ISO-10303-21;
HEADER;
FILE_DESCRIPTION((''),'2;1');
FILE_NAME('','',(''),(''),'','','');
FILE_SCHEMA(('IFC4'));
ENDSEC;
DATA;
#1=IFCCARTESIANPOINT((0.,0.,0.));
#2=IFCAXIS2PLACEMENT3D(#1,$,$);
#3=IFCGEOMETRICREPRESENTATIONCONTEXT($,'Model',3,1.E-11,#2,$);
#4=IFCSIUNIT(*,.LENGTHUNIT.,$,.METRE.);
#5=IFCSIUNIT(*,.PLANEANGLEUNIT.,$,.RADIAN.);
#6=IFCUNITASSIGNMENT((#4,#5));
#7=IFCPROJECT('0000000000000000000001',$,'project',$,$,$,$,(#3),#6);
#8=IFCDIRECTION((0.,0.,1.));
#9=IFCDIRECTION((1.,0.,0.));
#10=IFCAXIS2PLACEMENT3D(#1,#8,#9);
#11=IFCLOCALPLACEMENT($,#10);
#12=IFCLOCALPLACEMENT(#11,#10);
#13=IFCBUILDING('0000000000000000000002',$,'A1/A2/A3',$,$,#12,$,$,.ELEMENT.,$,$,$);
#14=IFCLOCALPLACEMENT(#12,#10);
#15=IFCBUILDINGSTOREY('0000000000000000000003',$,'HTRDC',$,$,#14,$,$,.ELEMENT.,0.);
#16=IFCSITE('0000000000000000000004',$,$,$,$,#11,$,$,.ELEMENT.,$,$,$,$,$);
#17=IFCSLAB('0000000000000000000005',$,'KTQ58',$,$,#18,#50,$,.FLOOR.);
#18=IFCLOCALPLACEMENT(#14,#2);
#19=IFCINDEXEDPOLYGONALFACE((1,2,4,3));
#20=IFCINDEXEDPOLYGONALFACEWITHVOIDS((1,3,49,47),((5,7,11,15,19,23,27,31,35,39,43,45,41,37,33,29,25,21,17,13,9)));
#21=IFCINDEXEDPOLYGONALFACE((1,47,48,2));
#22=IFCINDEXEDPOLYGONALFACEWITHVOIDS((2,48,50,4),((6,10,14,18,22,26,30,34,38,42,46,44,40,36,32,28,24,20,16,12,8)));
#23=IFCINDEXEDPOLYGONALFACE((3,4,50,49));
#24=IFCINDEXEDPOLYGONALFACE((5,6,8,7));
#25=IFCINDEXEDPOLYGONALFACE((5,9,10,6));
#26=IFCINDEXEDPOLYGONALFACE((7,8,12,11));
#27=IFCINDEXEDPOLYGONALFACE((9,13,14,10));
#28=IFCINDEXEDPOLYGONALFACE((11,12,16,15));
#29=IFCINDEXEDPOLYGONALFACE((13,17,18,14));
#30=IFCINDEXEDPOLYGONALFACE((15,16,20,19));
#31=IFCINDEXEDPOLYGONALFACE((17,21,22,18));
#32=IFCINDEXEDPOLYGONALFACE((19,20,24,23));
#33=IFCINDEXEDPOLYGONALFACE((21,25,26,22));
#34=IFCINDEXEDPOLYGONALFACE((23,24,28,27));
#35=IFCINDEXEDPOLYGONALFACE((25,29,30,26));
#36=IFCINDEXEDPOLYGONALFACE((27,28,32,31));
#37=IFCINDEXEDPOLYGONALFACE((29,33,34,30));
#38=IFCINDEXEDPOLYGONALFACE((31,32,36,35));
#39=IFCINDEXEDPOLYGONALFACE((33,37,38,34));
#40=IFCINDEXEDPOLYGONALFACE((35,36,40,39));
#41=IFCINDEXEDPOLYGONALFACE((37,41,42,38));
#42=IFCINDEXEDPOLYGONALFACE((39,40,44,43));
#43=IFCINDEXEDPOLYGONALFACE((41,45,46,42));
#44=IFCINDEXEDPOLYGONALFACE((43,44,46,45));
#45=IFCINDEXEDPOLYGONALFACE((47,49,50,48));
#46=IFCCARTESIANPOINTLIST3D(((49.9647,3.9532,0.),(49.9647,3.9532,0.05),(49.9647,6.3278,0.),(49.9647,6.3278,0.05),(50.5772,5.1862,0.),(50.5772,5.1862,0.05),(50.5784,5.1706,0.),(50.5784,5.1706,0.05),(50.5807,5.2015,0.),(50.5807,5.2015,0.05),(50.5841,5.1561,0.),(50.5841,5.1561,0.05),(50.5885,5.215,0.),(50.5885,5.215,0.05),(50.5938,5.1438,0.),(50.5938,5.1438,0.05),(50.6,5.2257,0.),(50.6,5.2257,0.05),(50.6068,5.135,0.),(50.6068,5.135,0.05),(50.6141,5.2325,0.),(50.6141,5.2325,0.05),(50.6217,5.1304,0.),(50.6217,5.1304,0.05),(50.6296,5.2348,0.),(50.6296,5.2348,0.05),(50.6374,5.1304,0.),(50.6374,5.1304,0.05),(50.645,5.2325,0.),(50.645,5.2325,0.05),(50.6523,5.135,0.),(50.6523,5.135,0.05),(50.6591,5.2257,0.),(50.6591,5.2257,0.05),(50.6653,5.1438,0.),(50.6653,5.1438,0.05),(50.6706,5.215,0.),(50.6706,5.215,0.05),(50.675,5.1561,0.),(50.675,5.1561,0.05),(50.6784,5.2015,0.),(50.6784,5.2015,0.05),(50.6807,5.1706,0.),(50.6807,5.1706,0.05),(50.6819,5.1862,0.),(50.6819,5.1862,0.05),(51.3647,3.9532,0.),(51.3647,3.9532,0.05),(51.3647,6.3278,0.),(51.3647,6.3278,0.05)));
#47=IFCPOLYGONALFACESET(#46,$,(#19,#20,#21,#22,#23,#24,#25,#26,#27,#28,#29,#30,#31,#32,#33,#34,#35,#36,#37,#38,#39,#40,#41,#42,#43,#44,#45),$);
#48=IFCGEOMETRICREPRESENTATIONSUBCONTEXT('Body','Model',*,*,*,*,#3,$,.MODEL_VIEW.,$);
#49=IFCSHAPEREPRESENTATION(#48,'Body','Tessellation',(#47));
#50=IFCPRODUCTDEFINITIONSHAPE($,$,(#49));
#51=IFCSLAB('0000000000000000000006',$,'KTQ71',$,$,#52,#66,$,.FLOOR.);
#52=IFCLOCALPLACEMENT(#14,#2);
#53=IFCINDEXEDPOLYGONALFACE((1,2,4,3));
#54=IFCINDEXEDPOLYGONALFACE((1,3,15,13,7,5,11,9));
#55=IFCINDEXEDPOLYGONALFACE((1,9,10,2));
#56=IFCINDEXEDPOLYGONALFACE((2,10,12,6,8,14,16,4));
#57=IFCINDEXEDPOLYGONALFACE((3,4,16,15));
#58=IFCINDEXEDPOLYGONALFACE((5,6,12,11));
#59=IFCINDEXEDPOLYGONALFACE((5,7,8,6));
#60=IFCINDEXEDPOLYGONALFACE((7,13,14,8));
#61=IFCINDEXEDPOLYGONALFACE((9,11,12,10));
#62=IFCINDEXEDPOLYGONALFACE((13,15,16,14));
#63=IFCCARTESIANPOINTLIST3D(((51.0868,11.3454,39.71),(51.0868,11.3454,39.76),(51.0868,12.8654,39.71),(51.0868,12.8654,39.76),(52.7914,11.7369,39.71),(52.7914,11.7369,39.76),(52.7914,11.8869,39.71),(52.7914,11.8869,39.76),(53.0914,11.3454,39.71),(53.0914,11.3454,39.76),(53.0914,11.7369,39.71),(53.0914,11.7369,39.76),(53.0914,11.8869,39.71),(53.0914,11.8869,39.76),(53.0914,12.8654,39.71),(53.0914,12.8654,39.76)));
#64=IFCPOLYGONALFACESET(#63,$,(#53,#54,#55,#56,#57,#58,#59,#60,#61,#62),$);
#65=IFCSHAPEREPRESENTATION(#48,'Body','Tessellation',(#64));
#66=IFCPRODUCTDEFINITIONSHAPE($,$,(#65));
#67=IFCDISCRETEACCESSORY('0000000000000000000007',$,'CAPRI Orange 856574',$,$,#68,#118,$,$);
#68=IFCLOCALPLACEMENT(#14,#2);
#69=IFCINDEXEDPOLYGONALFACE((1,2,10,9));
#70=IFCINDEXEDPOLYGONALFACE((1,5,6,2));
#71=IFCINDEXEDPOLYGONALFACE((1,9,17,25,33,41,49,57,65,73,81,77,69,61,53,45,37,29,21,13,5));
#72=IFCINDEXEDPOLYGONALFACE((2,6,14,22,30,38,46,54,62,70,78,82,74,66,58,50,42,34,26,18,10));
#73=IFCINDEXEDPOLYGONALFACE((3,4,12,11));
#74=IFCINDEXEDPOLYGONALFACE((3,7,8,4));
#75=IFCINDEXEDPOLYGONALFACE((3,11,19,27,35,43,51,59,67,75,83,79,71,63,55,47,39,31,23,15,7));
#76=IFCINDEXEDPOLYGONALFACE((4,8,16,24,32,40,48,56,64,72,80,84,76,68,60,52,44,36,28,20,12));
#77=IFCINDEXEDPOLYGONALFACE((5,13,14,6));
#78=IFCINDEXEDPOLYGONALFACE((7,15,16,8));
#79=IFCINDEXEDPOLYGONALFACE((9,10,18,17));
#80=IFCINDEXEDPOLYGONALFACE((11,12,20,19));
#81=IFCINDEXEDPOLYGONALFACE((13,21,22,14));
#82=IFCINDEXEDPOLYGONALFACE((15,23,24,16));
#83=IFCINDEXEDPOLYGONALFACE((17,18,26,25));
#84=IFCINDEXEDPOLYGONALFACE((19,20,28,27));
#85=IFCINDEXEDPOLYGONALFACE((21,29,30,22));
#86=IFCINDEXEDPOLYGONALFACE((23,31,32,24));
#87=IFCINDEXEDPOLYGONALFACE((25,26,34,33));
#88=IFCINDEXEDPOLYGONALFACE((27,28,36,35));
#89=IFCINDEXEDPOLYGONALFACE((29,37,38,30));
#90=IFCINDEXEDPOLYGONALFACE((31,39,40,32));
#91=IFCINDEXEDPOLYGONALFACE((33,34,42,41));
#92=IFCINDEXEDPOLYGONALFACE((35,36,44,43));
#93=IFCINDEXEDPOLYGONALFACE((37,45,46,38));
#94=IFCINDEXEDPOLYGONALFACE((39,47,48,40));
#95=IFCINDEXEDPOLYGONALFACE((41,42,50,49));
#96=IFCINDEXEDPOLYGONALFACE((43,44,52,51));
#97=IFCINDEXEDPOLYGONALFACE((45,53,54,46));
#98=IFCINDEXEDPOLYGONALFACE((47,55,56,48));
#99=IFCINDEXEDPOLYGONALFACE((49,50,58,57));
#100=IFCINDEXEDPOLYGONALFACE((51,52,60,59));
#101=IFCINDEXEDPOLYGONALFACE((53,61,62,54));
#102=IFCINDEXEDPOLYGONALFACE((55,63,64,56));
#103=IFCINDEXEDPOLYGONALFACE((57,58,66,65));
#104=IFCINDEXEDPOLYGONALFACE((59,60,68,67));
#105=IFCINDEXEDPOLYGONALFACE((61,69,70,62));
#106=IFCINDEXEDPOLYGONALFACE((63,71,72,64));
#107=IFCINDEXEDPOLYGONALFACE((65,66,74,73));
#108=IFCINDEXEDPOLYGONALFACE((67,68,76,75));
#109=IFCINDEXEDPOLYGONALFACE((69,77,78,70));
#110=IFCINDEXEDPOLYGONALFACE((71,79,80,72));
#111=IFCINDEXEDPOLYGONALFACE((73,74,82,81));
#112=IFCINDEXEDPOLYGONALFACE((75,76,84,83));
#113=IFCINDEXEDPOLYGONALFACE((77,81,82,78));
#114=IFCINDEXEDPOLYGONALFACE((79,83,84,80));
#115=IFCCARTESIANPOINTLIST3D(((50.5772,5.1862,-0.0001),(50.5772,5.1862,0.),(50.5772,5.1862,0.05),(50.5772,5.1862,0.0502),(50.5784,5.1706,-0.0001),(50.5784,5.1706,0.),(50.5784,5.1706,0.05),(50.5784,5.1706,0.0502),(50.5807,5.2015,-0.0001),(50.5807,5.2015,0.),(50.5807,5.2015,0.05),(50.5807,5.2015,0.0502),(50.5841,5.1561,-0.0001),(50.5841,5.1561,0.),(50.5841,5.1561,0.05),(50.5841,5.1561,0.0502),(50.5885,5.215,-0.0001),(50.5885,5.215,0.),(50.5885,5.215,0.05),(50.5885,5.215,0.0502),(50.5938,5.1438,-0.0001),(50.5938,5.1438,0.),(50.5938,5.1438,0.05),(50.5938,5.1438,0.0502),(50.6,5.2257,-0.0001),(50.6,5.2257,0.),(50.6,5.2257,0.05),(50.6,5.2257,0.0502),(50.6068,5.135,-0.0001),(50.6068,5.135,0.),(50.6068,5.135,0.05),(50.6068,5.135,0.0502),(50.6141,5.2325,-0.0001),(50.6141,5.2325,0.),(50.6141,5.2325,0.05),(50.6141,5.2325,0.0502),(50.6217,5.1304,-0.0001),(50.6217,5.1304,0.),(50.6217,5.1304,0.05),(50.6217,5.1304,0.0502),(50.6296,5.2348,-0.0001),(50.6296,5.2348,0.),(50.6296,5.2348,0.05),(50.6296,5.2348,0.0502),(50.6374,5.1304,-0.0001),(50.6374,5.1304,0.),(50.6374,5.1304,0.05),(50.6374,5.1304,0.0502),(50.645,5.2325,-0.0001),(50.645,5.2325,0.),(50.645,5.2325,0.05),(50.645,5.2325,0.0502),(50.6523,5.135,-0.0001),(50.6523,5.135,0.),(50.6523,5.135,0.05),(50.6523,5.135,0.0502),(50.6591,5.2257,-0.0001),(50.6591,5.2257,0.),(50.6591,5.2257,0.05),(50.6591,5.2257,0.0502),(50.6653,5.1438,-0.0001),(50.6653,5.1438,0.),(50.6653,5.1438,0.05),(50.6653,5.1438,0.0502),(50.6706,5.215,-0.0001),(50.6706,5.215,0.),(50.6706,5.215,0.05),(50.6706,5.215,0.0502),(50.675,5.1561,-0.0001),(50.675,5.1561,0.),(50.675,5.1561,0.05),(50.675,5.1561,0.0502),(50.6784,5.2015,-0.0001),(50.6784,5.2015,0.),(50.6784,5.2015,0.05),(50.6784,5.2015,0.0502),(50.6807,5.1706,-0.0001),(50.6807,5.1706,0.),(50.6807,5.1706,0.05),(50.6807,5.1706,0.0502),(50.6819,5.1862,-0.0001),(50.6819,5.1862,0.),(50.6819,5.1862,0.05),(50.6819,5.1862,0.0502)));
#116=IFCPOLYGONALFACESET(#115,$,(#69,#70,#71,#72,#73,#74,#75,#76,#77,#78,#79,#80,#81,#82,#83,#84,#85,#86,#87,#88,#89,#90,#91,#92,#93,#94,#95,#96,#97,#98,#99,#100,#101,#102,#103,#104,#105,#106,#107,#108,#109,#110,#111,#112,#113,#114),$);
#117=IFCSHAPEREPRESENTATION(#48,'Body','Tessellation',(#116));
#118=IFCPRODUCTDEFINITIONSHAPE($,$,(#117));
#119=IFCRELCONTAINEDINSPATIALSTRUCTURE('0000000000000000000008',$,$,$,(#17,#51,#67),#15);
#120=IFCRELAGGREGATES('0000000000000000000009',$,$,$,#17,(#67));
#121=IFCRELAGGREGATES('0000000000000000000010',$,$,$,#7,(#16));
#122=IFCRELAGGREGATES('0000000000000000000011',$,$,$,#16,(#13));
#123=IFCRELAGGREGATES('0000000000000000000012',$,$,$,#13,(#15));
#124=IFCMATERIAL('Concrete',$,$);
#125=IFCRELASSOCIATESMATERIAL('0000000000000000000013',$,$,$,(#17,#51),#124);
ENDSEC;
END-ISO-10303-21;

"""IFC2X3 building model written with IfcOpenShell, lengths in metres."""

from ifc_helpers import new_model, si_unit, frame, frame_2d, origin, origin_with_axes, origin_2d_with_axis, place, context, subcontext, project, spatial, polyline, circle, outline, extrude, material, element, aggregate, save


model = new_model("IFC2X3")

# Units and contexts
model_context = context("Model", 3, precision=1e-11, world=origin())
body_context = subcontext(model_context, "Body", "Model", "MODEL_VIEW")
ifc_project = project(units=[si_unit("LENGTHUNIT", "METRE"), si_unit("PLANEANGLEUNIT", "RADIAN")], contexts=[model_context])

# Site, building, storey
site_placement = place(None, origin_with_axes())
site = spatial("IfcSite", under=ifc_project, at=site_placement, CompositionType="ELEMENT")
building_placement = place(site_placement, origin_with_axes())
building = spatial("IfcBuilding", under=site, at=building_placement, Name="A1/A2/A3", CompositionType="ELEMENT")
storey_placement = place(building_placement, origin_with_axes())
storey = spatial("IfcBuildingStorey", under=building, at=storey_placement, Name="HTRDC", CompositionType="ELEMENT", Elevation=0.0)

# Slabs, openings
ifc_material = material(Name="Concrete")
slab_1_placement = place(storey_placement, frame((49.9647, 3.9532, 0.0), z_axis=(0.0, 0.0, 1.0), x_axis=(1.0, 0.0, 0.0)))
slab_1 = element("IfcSlab", 1, at=slab_1_placement, inside=storey, material=ifc_material, Name="KTQ58", PredefinedType="FLOOR", context=body_context, shape_type="SweptSolid", body=[
    extrude(outline(polyline([(0.0, 0.0), (0.0, -1.4), (2.3746, -1.4), (2.3746, 0.0), (0.0, 0.0)])), frame((0.0, 0.0, 0.0), z_axis=(0.0, 0.0, 1.0), x_axis=(0.0, 1.0, 0.0)), (0.0, 0.0, 1.0), 0.05),
])
opening_1_placement = place(slab_1_placement, frame((0.6649, 1.2291, 0.0), z_axis=(0.0, 0.0, 1.0), x_axis=(1.0, 0.0, 0.0)))
element("IfcOpeningElement", 2, at=opening_1_placement, cuts=slab_1, ObjectType="Opening", context=body_context, shape_type="SweptSolid", body=[
    extrude(circle(Radius=0.0525, at=origin_2d_with_axis()), frame((0.0, 0.0, 0.0), z_axis=(0.0, 0.0, 1.0), x_axis=(0.0, 1.0, 0.0)), (0.0, 0.0, 1.0), 0.05),
])
slab_2_placement = place(storey_placement, frame((53.0914, 11.3454, 39.71), z_axis=(0.0, 0.0, 1.0), x_axis=(0.0, 1.0, 0.0)))
slab_2 = element("IfcSlab", 3, at=slab_2_placement, inside=storey, material=ifc_material, Name="KTQ71", PredefinedType="FLOOR", context=body_context, shape_type="SweptSolid", body=[
    extrude(outline(polyline([(0.0, 0.0), (0.0, -1.52), (2.0046, -1.52), (2.0046, 0.0), (0.0, 0.0)])), frame((0.0, 0.0, 0.0), z_axis=(0.0, 0.0, 1.0), x_axis=(0.0, 1.0, 0.0)), (0.0, 0.0, 1.0), 0.05),
])
opening_2_placement = place(slab_2_placement, origin_with_axes())
element("IfcOpeningElement", 4, at=opening_2_placement, cuts=slab_2, ObjectType="Opening", context=body_context, shape_type="SweptSolid", body=[
    extrude(outline(polyline([(0.0, -0.3915), (0.0, -0.5415), (0.3, -0.5415), (0.3, -0.3915), (0.0, -0.3915)])), frame((0.0, 0.0, 0.0), z_axis=(0.0, 0.0, 1.0), x_axis=(0.0, 1.0, 0.0)), (0.0, 0.0, 1.0), 0.05),
])

# Discrete accessory
discrete_accessory_1_placement = place(storey_placement, frame((49.9647, 3.9532, -0.0001), z_axis=(0.0, 0.0, 1.0), x_axis=(1.0, 0.0, 0.0)))
discrete_accessory_1 = element("IfcDiscreteAccessory", 5, at=discrete_accessory_1_placement, inside=storey, Name="CAPRI Orange 856574", context=body_context, shape_type="SweptSolid", body=[
    extrude(circle(Radius=0.0525, at=frame_2d((1.2291, -0.6649), x_axis=(1.0, 0.0))), frame((0.0, 0.0, 0.0), z_axis=(0.0, 0.0, 1.0), x_axis=(0.0, 1.0, 0.0)), (0.0, 0.0, 1.0), 0.0503),
])
aggregate(slab_1, [discrete_accessory_1])

save(model, "model.ifc")
